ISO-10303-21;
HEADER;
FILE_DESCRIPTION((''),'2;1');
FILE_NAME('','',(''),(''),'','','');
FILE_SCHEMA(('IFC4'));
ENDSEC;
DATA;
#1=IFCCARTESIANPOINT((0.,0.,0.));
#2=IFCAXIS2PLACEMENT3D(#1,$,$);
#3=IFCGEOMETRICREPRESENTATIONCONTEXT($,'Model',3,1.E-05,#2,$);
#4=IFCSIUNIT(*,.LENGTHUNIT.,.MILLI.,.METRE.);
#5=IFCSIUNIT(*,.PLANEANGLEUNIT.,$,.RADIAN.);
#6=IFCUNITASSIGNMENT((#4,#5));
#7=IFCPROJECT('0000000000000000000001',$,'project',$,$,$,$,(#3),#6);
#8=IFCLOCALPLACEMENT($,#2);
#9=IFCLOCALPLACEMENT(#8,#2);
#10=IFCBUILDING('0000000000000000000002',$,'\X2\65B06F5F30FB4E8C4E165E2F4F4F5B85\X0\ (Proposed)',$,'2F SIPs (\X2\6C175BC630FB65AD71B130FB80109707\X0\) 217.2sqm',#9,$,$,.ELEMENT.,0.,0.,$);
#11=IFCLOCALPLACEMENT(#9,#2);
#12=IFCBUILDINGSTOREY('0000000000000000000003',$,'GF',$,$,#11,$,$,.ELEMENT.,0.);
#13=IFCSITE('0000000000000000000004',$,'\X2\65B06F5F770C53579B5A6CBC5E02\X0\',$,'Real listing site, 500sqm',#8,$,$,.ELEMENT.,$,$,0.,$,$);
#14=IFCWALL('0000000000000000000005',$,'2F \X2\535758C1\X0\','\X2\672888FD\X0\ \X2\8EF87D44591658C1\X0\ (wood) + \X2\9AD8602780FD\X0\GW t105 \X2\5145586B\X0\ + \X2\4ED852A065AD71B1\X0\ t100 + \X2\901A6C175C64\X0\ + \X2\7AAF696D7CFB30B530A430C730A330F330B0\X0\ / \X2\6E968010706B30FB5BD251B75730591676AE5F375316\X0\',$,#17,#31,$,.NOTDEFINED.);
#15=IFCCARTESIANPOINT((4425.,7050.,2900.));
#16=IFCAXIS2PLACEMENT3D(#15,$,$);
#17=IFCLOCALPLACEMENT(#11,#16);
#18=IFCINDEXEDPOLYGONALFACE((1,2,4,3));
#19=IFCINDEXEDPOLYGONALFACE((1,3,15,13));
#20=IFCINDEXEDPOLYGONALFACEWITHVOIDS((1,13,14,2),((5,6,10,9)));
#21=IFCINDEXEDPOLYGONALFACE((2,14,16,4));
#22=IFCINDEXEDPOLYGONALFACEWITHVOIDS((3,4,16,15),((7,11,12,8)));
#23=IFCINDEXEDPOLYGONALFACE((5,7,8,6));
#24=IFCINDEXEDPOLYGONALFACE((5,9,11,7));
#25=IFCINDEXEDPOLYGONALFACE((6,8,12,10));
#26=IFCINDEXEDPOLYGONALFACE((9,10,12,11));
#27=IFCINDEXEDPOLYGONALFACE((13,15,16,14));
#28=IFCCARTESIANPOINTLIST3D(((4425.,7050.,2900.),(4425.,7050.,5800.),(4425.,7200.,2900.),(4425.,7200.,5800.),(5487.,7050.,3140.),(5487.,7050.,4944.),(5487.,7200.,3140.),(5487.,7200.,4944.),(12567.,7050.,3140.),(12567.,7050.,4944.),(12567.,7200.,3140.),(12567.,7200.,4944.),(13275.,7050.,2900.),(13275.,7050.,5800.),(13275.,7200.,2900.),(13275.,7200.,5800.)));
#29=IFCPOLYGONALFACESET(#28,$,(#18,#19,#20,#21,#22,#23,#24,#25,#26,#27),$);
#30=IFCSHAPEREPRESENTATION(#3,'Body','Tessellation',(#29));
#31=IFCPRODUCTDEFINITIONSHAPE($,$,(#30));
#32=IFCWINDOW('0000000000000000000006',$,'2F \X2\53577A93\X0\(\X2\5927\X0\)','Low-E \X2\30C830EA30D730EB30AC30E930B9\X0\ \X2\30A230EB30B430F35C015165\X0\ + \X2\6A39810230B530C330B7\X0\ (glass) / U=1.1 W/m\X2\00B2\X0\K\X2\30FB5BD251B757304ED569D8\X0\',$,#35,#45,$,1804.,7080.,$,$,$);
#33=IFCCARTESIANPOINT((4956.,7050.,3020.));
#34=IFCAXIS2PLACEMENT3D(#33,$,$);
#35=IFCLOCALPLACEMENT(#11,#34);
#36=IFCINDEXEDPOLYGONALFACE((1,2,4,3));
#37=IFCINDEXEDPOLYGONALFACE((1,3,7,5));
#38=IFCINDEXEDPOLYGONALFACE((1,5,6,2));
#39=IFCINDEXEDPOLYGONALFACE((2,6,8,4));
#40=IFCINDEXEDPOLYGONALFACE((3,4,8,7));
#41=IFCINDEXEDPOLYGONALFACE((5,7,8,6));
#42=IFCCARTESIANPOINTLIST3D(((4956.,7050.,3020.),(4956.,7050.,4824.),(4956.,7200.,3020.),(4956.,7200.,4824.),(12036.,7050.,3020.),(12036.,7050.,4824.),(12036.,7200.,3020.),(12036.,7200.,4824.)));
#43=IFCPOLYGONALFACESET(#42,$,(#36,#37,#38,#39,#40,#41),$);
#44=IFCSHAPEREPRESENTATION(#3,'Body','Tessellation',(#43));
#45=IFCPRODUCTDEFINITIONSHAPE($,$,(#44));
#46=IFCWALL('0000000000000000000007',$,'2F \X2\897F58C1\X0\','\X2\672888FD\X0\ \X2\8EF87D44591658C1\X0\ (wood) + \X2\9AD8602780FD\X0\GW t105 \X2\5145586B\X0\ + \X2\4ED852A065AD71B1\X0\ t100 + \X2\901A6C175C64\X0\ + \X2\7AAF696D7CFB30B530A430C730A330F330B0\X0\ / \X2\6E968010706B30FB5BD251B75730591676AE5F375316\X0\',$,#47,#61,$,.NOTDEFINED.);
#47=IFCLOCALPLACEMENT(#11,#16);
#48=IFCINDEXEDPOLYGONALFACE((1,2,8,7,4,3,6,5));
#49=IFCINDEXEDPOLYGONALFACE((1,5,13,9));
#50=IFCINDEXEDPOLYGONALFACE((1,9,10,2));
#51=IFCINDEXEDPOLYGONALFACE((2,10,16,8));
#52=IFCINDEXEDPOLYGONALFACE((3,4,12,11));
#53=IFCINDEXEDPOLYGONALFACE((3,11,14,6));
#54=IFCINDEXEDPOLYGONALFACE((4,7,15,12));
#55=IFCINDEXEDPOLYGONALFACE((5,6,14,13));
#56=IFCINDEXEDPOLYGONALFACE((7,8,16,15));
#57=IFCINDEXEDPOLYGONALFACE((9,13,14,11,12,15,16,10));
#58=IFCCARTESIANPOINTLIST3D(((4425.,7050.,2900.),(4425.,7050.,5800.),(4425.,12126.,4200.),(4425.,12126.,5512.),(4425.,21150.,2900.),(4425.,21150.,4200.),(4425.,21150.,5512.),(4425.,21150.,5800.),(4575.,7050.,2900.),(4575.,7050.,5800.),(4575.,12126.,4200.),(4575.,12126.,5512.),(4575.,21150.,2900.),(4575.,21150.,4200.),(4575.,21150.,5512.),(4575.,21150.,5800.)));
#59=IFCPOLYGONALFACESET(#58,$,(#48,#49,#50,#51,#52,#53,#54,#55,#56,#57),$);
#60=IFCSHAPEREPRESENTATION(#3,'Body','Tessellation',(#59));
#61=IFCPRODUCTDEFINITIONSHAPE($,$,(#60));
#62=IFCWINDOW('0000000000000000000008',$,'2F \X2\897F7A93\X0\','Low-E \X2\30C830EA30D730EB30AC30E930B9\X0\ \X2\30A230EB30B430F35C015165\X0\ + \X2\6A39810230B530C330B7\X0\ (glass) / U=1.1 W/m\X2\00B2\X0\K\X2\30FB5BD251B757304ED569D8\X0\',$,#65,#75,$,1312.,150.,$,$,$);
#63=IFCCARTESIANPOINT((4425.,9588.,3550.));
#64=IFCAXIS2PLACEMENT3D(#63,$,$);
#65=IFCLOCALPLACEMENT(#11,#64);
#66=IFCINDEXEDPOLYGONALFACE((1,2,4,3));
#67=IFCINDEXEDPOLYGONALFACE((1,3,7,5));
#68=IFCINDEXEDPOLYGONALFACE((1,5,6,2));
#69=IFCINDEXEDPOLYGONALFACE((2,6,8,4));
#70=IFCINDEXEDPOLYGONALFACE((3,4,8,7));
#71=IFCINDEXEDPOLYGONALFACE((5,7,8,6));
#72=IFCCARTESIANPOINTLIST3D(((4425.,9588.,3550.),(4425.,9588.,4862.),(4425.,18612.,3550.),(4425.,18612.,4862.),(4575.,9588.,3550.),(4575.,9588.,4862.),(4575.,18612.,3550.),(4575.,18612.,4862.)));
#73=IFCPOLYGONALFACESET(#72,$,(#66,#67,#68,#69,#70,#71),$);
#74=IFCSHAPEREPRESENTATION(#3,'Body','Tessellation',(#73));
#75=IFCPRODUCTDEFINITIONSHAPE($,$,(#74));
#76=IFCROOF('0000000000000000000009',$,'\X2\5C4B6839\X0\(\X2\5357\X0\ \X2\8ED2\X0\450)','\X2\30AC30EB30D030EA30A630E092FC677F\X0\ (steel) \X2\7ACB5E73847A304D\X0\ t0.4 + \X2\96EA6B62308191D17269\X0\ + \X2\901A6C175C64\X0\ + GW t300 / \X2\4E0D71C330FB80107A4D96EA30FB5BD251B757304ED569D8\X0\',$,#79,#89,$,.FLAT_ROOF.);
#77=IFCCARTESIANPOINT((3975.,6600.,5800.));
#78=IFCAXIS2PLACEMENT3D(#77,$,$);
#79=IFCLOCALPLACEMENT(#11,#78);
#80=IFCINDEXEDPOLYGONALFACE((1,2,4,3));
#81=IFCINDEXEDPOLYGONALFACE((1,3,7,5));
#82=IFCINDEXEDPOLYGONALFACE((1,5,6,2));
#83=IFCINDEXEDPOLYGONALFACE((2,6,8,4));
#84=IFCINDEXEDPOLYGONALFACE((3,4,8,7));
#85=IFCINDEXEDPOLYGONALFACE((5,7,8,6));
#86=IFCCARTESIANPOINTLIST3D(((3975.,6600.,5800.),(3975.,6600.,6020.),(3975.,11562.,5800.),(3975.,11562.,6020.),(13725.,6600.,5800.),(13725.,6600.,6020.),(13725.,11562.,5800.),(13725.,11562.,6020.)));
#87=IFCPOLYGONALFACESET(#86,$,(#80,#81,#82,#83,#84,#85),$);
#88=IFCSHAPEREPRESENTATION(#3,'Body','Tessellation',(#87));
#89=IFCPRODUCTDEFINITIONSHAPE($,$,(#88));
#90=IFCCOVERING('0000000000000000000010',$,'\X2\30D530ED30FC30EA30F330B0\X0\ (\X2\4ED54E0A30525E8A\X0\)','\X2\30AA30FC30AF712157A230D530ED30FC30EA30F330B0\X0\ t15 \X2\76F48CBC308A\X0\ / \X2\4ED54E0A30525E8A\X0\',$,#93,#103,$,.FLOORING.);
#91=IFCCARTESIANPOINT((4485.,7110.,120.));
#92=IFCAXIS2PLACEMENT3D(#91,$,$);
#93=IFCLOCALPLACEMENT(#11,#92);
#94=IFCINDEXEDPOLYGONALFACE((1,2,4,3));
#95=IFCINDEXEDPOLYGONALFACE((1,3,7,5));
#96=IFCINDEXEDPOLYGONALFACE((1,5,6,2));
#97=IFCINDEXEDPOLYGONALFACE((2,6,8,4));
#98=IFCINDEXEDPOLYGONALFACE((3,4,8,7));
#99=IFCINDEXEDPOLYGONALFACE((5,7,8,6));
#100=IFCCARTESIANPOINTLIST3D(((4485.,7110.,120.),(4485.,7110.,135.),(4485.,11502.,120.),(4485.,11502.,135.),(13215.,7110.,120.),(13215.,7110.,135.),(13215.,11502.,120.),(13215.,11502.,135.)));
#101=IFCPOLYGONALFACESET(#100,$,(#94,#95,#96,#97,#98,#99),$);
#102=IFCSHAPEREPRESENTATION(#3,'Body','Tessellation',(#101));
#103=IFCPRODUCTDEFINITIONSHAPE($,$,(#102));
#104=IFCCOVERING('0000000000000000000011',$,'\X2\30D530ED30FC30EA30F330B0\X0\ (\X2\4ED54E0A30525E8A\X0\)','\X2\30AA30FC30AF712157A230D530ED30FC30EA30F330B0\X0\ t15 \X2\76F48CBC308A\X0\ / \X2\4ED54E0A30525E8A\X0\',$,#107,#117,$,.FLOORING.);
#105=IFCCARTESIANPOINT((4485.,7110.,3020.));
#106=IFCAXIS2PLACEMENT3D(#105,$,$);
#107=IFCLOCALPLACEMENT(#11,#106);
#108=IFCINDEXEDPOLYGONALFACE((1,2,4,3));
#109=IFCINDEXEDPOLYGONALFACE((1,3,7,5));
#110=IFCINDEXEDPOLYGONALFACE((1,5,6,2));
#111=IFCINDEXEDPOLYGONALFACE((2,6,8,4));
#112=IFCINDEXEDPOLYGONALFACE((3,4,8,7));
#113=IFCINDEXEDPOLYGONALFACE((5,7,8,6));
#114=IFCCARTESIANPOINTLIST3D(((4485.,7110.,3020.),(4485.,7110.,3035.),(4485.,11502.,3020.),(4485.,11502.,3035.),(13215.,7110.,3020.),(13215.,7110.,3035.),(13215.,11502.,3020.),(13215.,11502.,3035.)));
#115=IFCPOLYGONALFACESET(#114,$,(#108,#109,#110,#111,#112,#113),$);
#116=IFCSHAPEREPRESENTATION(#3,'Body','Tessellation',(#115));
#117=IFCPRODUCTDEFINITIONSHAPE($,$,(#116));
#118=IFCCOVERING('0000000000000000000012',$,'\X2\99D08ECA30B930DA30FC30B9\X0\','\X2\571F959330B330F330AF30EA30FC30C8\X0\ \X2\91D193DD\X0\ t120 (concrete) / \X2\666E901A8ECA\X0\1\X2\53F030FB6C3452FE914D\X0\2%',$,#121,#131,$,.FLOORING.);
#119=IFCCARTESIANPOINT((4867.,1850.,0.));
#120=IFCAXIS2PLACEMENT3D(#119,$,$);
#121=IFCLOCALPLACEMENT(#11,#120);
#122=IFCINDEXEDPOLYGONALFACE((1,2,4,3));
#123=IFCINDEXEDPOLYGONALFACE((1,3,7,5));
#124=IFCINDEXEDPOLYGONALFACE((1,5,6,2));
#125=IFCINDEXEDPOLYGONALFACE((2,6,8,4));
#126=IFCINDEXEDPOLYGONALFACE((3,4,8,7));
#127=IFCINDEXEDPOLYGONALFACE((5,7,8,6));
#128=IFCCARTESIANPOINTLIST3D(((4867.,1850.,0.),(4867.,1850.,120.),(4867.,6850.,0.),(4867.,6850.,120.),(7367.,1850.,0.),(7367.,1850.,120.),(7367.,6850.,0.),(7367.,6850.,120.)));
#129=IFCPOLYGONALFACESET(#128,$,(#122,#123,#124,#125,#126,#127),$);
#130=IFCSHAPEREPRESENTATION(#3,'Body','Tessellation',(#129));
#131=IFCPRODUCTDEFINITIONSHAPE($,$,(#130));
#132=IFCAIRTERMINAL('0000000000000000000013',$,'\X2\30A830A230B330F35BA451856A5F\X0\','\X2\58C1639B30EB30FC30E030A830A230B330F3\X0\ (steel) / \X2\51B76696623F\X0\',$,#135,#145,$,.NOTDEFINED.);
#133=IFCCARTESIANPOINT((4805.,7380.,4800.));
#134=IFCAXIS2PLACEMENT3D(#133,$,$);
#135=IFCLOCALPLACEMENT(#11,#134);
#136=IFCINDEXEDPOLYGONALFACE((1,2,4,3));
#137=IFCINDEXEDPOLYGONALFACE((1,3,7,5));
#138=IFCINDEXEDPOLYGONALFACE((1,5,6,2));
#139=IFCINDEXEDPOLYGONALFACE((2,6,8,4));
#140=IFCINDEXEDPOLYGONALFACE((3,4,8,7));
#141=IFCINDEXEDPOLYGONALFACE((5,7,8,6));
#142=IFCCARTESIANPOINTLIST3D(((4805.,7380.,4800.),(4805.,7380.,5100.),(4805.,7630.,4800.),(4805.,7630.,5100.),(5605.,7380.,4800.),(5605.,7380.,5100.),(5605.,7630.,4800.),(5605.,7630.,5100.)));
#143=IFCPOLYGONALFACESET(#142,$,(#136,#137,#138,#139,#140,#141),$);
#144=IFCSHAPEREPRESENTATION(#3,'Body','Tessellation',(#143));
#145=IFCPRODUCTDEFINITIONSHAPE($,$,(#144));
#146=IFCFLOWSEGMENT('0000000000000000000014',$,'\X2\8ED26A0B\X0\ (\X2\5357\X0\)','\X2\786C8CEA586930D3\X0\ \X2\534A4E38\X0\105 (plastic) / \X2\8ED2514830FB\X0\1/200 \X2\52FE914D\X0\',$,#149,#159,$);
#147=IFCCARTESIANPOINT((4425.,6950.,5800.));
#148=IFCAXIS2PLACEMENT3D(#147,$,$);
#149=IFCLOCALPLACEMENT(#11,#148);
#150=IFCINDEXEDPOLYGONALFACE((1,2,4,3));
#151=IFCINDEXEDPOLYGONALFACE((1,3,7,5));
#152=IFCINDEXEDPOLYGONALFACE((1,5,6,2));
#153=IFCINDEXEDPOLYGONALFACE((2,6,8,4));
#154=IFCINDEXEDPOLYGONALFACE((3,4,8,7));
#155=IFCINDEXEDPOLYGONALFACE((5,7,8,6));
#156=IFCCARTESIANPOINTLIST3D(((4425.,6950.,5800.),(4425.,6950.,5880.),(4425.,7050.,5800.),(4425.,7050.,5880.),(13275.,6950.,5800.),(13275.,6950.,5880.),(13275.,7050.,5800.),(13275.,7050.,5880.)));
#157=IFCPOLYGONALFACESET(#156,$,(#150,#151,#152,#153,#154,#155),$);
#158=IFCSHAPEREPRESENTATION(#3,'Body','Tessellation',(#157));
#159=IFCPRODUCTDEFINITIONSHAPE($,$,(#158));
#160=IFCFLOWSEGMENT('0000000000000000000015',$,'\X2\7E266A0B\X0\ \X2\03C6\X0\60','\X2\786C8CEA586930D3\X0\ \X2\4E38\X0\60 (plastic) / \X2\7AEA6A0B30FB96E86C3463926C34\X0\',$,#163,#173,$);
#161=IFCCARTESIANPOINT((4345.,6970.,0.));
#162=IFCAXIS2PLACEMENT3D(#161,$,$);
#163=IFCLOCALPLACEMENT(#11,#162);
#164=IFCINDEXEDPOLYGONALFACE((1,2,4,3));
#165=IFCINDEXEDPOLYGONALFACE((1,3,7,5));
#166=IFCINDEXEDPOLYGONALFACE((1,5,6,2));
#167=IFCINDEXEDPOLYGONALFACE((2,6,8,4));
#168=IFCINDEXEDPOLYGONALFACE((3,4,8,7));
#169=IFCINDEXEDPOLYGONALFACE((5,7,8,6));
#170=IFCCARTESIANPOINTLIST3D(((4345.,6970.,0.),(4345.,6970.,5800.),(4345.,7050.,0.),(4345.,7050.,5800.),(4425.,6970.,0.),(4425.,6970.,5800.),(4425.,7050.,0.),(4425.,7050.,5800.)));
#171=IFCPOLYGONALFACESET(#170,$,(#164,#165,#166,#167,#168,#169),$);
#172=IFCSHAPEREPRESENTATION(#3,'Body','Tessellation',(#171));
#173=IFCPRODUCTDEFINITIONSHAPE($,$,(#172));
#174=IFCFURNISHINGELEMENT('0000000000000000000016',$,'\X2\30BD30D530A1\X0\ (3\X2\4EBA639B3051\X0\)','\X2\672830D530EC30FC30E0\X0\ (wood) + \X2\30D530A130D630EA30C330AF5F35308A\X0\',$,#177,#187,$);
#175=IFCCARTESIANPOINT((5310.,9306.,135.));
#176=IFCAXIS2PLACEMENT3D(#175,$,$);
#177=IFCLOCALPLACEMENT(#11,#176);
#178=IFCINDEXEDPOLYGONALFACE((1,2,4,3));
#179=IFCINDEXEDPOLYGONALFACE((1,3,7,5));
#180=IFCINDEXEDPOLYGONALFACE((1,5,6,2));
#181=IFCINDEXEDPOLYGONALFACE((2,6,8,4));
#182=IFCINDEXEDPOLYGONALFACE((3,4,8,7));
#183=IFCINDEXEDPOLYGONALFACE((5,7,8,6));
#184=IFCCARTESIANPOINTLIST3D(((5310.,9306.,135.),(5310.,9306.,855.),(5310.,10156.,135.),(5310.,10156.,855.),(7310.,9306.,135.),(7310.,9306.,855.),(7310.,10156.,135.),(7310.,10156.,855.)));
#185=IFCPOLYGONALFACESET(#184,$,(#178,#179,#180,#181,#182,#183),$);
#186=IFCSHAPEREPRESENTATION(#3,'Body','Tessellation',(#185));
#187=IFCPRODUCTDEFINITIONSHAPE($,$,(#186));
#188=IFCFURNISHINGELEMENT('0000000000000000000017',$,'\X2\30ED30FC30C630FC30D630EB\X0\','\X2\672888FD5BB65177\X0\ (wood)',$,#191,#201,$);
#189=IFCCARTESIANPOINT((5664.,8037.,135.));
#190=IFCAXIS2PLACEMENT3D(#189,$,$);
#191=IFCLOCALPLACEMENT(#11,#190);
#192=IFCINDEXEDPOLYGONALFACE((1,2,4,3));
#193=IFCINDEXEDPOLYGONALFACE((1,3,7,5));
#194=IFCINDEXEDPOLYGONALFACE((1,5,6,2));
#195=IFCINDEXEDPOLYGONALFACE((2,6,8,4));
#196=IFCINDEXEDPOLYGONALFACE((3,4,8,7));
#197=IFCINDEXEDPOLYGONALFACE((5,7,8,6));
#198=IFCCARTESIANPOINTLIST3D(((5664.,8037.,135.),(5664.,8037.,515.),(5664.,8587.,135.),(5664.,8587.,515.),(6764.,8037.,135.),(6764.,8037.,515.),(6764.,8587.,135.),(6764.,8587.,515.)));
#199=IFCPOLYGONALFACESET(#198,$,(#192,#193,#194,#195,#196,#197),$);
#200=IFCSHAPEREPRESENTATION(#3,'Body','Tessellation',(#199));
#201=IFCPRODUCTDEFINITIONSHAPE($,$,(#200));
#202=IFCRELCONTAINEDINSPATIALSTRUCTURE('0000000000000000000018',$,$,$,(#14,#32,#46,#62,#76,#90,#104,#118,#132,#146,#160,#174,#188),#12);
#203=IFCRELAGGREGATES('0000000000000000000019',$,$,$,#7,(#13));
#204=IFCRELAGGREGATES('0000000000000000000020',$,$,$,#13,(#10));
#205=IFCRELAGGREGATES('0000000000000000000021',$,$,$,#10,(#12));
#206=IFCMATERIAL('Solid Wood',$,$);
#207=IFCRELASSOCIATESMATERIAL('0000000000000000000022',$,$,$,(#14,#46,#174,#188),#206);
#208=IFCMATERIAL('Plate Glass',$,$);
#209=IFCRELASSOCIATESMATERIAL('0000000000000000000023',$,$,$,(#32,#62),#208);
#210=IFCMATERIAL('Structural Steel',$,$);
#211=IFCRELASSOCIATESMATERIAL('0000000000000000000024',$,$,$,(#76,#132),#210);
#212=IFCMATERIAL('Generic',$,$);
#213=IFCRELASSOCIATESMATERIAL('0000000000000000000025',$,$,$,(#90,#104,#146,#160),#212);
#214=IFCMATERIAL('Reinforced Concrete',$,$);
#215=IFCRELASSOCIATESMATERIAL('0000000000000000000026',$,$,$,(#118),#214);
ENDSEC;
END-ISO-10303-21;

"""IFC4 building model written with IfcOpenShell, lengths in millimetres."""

from ifc_helpers import new_model, si_unit, frame, frame_2d, origin, place, context, project, spatial, rectangle, extrude, material, element, fill, save


model = new_model("IFC4")

# Units and contexts
model_context = context("Model", 3, precision=1e-05, world=origin())
ifc_project = project(units=[si_unit("LENGTHUNIT", "METRE", prefix="MILLI"), si_unit("PLANEANGLEUNIT", "RADIAN")], contexts=[model_context])

# Site, building, storey
site_placement = place(None, origin())
site = spatial("IfcSite", under=ifc_project, at=site_placement, Name="新潟県南魚沼市", ObjectType="Real listing site, 500sqm", CompositionType="ELEMENT", RefElevation=0.0)
building_placement = place(site_placement, origin())
building = spatial("IfcBuilding", under=site, at=building_placement, Name="新潟・二世帯住宅 (Proposed)", ObjectType="2F SIPs (気密・断熱・耐震) 217.2sqm", CompositionType="ELEMENT", ElevationOfRefHeight=0.0, ElevationOfTerrain=0.0)
storey_placement = place(building_placement, origin())
storey = spatial("IfcBuildingStorey", under=building, at=storey_placement, Name="GF", CompositionType="ELEMENT", Elevation=0.0)

# Shared definitions
ifc_material_1 = material(Name="Solid Wood")

# Shared definitions
ifc_material_2 = material(Name="Reinforced Concrete")

# Shared definitions
ifc_material_3 = material(Name="Plate Glass")

# Walls, openings, windows
wall_1_placement = place(storey_placement, frame((4425.0, 7050.0, 2900.0)))
wall_1 = element("IfcWall", 1, at=wall_1_placement, inside=storey, material=ifc_material_1, Name="2F 南壁", Description="木製 軸組外壁 (wood) + 高性能GW t105 充填 + 付加断熱 t100 + 通気層 + 窯業系サイディング / 準耐火・寒冷地外皮強化", PredefinedType="NOTDEFINED", context=model_context, shape_type="SweptSolid", body=[
    extrude(rectangle(XDim=8850.0, YDim=150.0, at=frame_2d((4425.0, 75.0))), frame((4425.0, 7050.0, 2900.0)), (0.0, 0.0, 1.0), 2900.0),
])
opening_1_placement = place(storey_placement, frame((4956.0, 7050.0, 3020.0)))
opening_1 = element("IfcOpeningElement", 2, at=opening_1_placement, cuts=wall_1, PredefinedType="NOTDEFINED", context=model_context, shape_type="SweptSolid", body=[
    extrude(rectangle(XDim=7080.0, YDim=150.0, at=frame_2d((3540.0, 75.0))), frame((4956.0, 7050.0, 3020.0)), (0.0, 0.0, 1.0), 1804.0),
])
window_1_placement = place(storey_placement, frame((4956.0, 7050.0, 3020.0)))
window_1 = element("IfcWindow", 3, at=window_1_placement, inside=storey, material=ifc_material_3, Name="2F 南窓(大)", Description="Low-E トリプルガラス アルゴン封入 + 樹脂サッシ (glass) / U=1.1 W/m²K・寒冷地仕様", OverallHeight=1804.0, OverallWidth=7080.0, context=model_context, shape_type="SweptSolid", body=[
    extrude(rectangle(XDim=7080.0, YDim=150.0, at=frame_2d((3540.0, 75.0))), frame((4956.0, 7050.0, 3020.0)), (0.0, 0.0, 1.0), 1804.0),
])
fill(opening_1, window_1)
wall_2_placement = place(storey_placement, frame((4425.0, 7050.0, 2900.0)))
wall_2 = element("IfcWall", 4, at=wall_2_placement, inside=storey, material=ifc_material_1, Name="2F 西壁", Description="木製 軸組外壁 (wood) + 高性能GW t105 充填 + 付加断熱 t100 + 通気層 + 窯業系サイディング / 準耐火・寒冷地外皮強化", PredefinedType="NOTDEFINED", context=model_context, shape_type="SweptSolid", body=[
    extrude(rectangle(XDim=150.0, YDim=14100.0, at=frame_2d((75.0, 7050.0))), frame((4425.0, 7050.0, 2900.0)), (0.0, 0.0, 1.0), 2900.0),
])
opening_2_placement = place(storey_placement, frame((4425.0, 9588.0, 3550.0)))
opening_2 = element("IfcOpeningElement", 5, at=opening_2_placement, cuts=wall_2, PredefinedType="NOTDEFINED", context=model_context, shape_type="SweptSolid", body=[
    extrude(rectangle(XDim=150.0, YDim=9024.0, at=frame_2d((75.0, 4512.0))), frame((4425.0, 9588.0, 3550.0)), (0.0, 0.0, 1.0), 1312.0),
])
window_2_placement = place(storey_placement, frame((4425.0, 9588.0, 3550.0)))
window_2 = element("IfcWindow", 6, at=window_2_placement, inside=storey, material=ifc_material_3, Name="2F 西窓", Description="Low-E トリプルガラス アルゴン封入 + 樹脂サッシ (glass) / U=1.1 W/m²K・寒冷地仕様", OverallHeight=1312.0, OverallWidth=150.0, context=model_context, shape_type="SweptSolid", body=[
    extrude(rectangle(XDim=150.0, YDim=9024.0, at=frame_2d((75.0, 4512.0))), frame((4425.0, 9588.0, 3550.0)), (0.0, 0.0, 1.0), 1312.0),
])
fill(opening_2, window_2)

# Roof
ifc_material_4 = material(Name="Structural Steel")
for number, where, name in (
    (7, (3975.0, 6600.0, 5800.0), "屋根(南 軒450)"),
):
    element("IfcRoof", number, at=place(storey_placement, frame(where)), inside=storey, material=ifc_material_4, Name=name, Description="ガルバリウム鋼板 (steel) 立平葺き t0.4 + 雪止め金物 + 通気層 + GW t300 / 不燃・耐積雪・寒冷地仕様", PredefinedType="FLAT_ROOF", context=model_context, shape_type="SweptSolid", body=[
        extrude(rectangle(XDim=9750.0, YDim=4962.0, at=frame_2d((4875.0, 2481.0))), frame((3975.0, 6600.0, 5800.0)), (0.0, 0.0, 1.0), 220.0),
    ])

# Coverings
ifc_material_5 = material(Name="Generic")
covering_1_placement = place(storey_placement, frame((4485.0, 7110.0, 120.0)))
element("IfcCovering", 8, at=covering_1_placement, inside=storey, material=ifc_material_5, Name="フローリング (仕上げ床)", Description="オーク無垢フローリング t15 直貼り / 仕上げ床", PredefinedType="FLOORING", context=model_context, shape_type="SweptSolid", body=[
    extrude(rectangle(XDim=8730.0, YDim=4392.0, at=frame_2d((4365.0, 2196.0))), frame((4485.0, 7110.0, 120.0)), (0.0, 0.0, 1.0), 15.0),
])
covering_2_placement = place(storey_placement, frame((4485.0, 7110.0, 3020.0)))
element("IfcCovering", 9, at=covering_2_placement, inside=storey, material=ifc_material_5, Name="フローリング (仕上げ床)", Description="オーク無垢フローリング t15 直貼り / 仕上げ床", PredefinedType="FLOORING", context=model_context, shape_type="SweptSolid", body=[
    extrude(rectangle(XDim=8730.0, YDim=4392.0, at=frame_2d((4365.0, 2196.0))), frame((4485.0, 7110.0, 3020.0)), (0.0, 0.0, 1.0), 15.0),
])
covering_3_placement = place(storey_placement, frame((4867.0, 1850.0, 0.0)))
element("IfcCovering", 10, at=covering_3_placement, inside=storey, material=ifc_material_2, Name="駐車スペース", Description="土間コンクリート 金鏝 t120 (concrete) / 普通車1台・水勾配2%", PredefinedType="FLOORING", context=model_context, shape_type="SweptSolid", body=[
    extrude(rectangle(XDim=2500.0, YDim=5000.0, at=frame_2d((1250.0, 2500.0))), frame((4867.0, 1850.0, 0.0)), (0.0, 0.0, 1.0), 120.0),
])

# Air terminal
air_terminal_placement = place(storey_placement, frame((4805.0, 7380.0, 4800.0)))
element("IfcAirTerminal", 11, at=air_terminal_placement, inside=storey, material=ifc_material_4, Name="エアコン室内機", Description="壁掛ルームエアコン (steel) / 冷暖房", PredefinedType="NOTDEFINED", context=model_context, shape_type="SweptSolid", body=[
    extrude(rectangle(XDim=800.0, YDim=250.0, at=frame_2d((400.0, 125.0))), frame((4805.0, 7380.0, 4800.0)), (0.0, 0.0, 1.0), 300.0),
])

# Flow segments
flow_segment_1_placement = place(storey_placement, frame((4425.0, 6950.0, 5800.0)))
element("IfcFlowSegment", 12, at=flow_segment_1_placement, inside=storey, material=ifc_material_5, Name="軒樋 (南)", Description="硬質塩ビ 半丸105 (plastic) / 軒先・1/200 勾配", context=model_context, shape_type="SweptSolid", body=[
    extrude(rectangle(XDim=8850.0, YDim=100.0, at=frame_2d((4425.0, 50.0))), frame((4425.0, 6950.0, 5800.0)), (0.0, 0.0, 1.0), 80.0),
])
flow_segment_2_placement = place(storey_placement, frame((4345.0, 6970.0, 0.0)))
element("IfcFlowSegment", 13, at=flow_segment_2_placement, inside=storey, material=ifc_material_5, Name="縦樋 φ60", Description="硬質塩ビ 丸60 (plastic) / 竪樋・雨水排水", context=model_context, shape_type="SweptSolid", body=[
    extrude(rectangle(XDim=80.0, YDim=80.0, at=frame_2d((40.0, 40.0))), frame((4345.0, 6970.0, 0.0)), (0.0, 0.0, 1.0), 5800.0),
])

# Furnishing elements
furnishing_1_placement = place(storey_placement, frame((5310.0, 9306.0, 135.0)))
element("IfcFurnishingElement", 14, at=furnishing_1_placement, inside=storey, material=ifc_material_1, Name="ソファ (3人掛け)", Description="木フレーム (wood) + ファブリック張り", context=model_context, shape_type="SweptSolid", body=[
    extrude(rectangle(XDim=2000.0, YDim=850.0, at=frame_2d((1000.0, 425.0))), frame((5310.0, 9306.0, 135.0)), (0.0, 0.0, 1.0), 720.0),
])
furnishing_2_placement = place(storey_placement, frame((5664.0, 8037.0, 135.0)))
element("IfcFurnishingElement", 15, at=furnishing_2_placement, inside=storey, material=ifc_material_1, Name="ローテーブル", Description="木製家具 (wood)", context=model_context, shape_type="SweptSolid", body=[
    extrude(rectangle(XDim=1100.0, YDim=550.0, at=frame_2d((550.0, 275.0))), frame((5664.0, 8037.0, 135.0)), (0.0, 0.0, 1.0), 380.0),
])

save(model, "model.ifc")
